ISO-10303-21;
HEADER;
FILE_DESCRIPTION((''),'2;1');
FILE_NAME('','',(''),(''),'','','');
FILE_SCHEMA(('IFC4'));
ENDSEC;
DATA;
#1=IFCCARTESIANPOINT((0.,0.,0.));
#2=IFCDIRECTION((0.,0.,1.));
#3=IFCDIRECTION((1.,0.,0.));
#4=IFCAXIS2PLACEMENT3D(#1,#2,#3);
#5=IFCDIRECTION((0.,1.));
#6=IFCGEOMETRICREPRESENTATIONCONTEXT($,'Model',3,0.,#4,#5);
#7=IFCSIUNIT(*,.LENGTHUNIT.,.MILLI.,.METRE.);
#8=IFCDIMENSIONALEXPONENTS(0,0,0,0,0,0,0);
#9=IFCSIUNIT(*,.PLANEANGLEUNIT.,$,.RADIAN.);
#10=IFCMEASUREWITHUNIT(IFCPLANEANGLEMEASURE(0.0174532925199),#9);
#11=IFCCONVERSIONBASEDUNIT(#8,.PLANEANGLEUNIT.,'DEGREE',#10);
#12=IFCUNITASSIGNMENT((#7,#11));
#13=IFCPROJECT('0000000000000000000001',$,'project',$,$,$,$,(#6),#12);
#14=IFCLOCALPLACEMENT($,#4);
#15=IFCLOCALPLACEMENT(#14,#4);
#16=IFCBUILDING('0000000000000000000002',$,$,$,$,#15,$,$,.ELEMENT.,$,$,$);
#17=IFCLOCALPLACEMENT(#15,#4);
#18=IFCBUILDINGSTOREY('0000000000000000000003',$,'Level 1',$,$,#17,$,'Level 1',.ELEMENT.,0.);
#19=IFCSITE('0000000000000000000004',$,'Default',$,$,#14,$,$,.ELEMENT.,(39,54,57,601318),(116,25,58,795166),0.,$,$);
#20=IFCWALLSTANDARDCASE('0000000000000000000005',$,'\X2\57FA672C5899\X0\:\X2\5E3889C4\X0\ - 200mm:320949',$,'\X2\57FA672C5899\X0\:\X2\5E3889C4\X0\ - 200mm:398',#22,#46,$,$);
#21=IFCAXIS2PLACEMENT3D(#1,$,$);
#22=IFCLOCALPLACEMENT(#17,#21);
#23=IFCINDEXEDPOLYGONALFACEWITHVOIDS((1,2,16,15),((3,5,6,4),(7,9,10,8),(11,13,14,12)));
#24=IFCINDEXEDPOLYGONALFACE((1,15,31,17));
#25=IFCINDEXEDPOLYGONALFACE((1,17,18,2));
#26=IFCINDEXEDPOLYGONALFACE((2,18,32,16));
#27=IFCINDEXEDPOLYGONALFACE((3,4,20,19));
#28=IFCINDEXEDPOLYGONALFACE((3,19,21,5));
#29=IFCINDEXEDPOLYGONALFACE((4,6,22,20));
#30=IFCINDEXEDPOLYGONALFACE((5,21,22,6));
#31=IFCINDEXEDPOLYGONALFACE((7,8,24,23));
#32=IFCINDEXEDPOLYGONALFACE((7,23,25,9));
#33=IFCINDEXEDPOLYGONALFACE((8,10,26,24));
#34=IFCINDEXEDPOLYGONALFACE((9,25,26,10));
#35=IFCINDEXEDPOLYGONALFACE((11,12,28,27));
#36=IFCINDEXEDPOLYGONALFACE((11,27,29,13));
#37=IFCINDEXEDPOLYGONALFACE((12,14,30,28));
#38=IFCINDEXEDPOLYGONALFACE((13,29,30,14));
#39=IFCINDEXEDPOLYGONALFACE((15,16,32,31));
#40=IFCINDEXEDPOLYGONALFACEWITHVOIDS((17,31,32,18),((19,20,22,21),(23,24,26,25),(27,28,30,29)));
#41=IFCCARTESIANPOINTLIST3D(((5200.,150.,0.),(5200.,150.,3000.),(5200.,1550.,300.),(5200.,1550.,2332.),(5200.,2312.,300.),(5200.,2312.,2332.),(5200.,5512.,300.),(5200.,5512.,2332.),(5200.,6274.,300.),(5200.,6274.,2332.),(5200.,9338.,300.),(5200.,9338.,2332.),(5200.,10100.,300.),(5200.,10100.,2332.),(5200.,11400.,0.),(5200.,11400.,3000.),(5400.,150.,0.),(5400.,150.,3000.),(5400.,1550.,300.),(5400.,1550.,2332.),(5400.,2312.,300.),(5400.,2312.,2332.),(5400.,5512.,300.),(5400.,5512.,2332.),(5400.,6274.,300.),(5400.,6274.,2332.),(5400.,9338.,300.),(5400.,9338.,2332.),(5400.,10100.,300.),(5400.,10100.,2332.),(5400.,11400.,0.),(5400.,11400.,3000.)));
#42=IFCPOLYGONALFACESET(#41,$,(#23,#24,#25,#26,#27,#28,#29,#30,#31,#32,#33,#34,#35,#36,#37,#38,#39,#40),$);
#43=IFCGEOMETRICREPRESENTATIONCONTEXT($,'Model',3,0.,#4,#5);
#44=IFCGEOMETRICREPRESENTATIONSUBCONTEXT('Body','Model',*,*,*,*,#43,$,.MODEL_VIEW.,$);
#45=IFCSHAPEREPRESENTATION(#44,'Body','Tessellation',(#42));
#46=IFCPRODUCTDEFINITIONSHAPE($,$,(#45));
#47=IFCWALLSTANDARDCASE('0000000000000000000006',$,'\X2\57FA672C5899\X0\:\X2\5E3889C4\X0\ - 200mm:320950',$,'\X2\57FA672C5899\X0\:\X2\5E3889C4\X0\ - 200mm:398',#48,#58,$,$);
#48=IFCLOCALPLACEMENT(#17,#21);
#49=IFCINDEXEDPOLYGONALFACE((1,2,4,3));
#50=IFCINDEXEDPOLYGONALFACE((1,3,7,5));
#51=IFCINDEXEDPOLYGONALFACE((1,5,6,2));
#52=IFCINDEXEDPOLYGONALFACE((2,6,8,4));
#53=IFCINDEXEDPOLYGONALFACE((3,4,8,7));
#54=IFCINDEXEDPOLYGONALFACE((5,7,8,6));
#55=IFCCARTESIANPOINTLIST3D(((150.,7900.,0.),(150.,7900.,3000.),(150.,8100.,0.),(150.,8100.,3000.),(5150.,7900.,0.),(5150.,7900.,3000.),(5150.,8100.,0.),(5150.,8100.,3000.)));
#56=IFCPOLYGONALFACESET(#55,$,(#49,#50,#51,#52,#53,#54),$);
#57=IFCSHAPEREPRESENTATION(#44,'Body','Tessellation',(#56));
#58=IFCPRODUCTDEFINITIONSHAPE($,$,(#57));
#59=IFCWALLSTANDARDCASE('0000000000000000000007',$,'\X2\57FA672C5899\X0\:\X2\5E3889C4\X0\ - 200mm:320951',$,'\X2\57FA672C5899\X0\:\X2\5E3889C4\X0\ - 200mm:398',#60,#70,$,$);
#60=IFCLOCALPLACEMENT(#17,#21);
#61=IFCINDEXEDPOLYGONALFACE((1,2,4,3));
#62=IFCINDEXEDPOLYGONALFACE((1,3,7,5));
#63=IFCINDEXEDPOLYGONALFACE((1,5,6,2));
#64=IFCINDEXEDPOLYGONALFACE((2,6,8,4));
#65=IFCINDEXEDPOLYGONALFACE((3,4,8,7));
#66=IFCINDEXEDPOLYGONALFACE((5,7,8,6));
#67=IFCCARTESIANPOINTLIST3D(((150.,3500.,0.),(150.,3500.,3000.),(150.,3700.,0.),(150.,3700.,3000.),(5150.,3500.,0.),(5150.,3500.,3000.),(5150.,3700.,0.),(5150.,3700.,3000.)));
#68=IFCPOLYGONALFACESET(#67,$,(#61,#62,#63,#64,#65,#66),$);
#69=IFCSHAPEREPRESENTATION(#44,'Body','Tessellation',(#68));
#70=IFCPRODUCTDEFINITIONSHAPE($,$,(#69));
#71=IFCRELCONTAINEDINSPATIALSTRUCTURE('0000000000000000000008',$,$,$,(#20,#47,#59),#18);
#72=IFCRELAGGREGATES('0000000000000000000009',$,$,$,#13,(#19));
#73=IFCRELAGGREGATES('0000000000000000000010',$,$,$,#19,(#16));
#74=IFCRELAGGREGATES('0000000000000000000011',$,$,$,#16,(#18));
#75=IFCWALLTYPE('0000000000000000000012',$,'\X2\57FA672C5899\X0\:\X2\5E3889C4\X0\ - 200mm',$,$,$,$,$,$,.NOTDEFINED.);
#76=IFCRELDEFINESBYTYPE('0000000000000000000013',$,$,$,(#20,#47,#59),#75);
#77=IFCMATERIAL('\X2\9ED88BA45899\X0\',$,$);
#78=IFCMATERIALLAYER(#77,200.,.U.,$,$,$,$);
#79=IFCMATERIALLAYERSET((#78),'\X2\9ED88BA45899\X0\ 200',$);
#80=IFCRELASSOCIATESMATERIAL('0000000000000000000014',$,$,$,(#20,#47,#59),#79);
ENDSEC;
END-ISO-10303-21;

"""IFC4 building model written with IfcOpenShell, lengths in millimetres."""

from ifc_helpers import new_model, entity, si_unit, converted_unit, direction, frame, origin_with_axes, place, context, subcontext, project, spatial, polyline, outline, extrude, material, layer, layer_set, layer_usage, type_object, element, save


model = new_model("IFC4")

# Units and contexts
model_context_1 = context("Model", 3, precision=0.0, world=origin_with_axes(), true_north=direction((0.0, 1.0)))
model_context_2 = context("Model", 3, precision=0.0, world=origin_with_axes(), true_north=direction((0.0, 1.0)))
body_context_1 = subcontext(model_context_2, "Body", "Model", "MODEL_VIEW")
ifc_project = project(units=[si_unit("LENGTHUNIT", "METRE", prefix="MILLI"), converted_unit("PLANEANGLEUNIT", "DEGREE", entity("IfcPlaneAngleMeasure", 0.0174532925199), si_unit("PLANEANGLEUNIT", "RADIAN"), dimensions=[0, 0, 0, 0, 0, 0, 0])], contexts=[model_context_1])

# Site, building, storey
site_placement = place(None, origin_with_axes())
site = spatial("IfcSite", under=ifc_project, at=site_placement, Name="Default", CompositionType="ELEMENT", RefLatitude=(39, 54, 57, 601318), RefLongitude=(116, 25, 58, 795166), RefElevation=0.0)
building_placement = place(site_placement, origin_with_axes())
building = spatial("IfcBuilding", under=site, at=building_placement, CompositionType="ELEMENT")
storey_placement = place(building_placement, origin_with_axes())
storey = spatial("IfcBuildingStorey", under=building, at=storey_placement, Name="Level 1", LongName="Level 1", CompositionType="ELEMENT", Elevation=0.0)

# Shared definitions
placement_1 = place(None, origin_with_axes())
placement_2 = place(placement_1, origin_with_axes())
placement_3 = place(placement_2, origin_with_axes())

# Wall, openings
ifc_material_1 = material(Name="默认墙")
ifc_layer_1 = layer(ifc_material_1, 200.0, ventilated="UNKNOWN")
ifc_layer_set_1 = layer_set([ifc_layer_1], Name="默认墙 200")
ifc_layer_usage_1 = layer_usage(ifc_layer_set_1, "AXIS2", "POSITIVE", -100.0)
wall_type_1 = type_object("IfcWallType", Name="基本墙:常规 - 200mm", PredefinedType="NOTDEFINED")
wall_1_placement = place(placement_3, frame((5300.0, 11500.0, 0.0), z_axis=(0.0, 0.0, 1.0), x_axis=(0.0, -1.0, 0.0)))
wall_1 = element("IfcWallStandardCase", 1, at=wall_1_placement, inside=storey, type_object=wall_type_1, material=ifc_layer_usage_1, Name="基本墙:常规 - 200mm:320949", ObjectType="基本墙:常规 - 200mm:398", context=body_context_1, shape_type="SweptSolid", body=[
    extrude(outline(polyline([(100.0, -100.0), (11350.0, -100.0), (11350.0, 100.0), (100.0, 100.0), (100.0, -100.0)])), origin_with_axes(), (0.0, 0.0, 1.0), 3000.0),
])
opening_1_placement = place(wall_1_placement, frame((9569.0, 0.0, 300.0), z_axis=(0.0, 0.0, 1.0), x_axis=(1.0, 0.0, 0.0)))
element("IfcOpeningElement", 2, at=opening_1_placement, cuts=wall_1, context=body_context_1, shape_type="SweptSolid", body=[
    extrude(outline(polyline([(-381.0, -2032.0), (381.0, -2032.0), (381.0, 0.0), (-381.0, 0.0), (-381.0, -2032.0)])), frame((0.0, -100.0, 0.0), z_axis=(0.0, 1.0, 0.0), x_axis=(1.0, 0.0, 0.0)), (0.0, 0.0, 1.0), 200.0),
])
opening_2_placement = place(wall_1_placement, frame((5607.0, 0.0, 300.0), z_axis=(0.0, 0.0, 1.0), x_axis=(1.0, 0.0, 0.0)))
element("IfcOpeningElement", 3, at=opening_2_placement, cuts=wall_1, context=body_context_1, shape_type="SweptSolid", body=[
    extrude(outline(polyline([(-381.0, -2032.0), (381.0, -2032.0), (381.0, 0.0), (-381.0, 0.0), (-381.0, -2032.0)])), frame((0.0, -100.0, 0.0), z_axis=(0.0, 1.0, 0.0), x_axis=(1.0, 0.0, 0.0)), (0.0, 0.0, 1.0), 200.0),
])
opening_3_placement = place(wall_1_placement, frame((1781.0, 0.0, 300.0), z_axis=(0.0, 0.0, 1.0), x_axis=(1.0, 0.0, 0.0)))
element("IfcOpeningElement", 4, at=opening_3_placement, cuts=wall_1, context=body_context_1, shape_type="SweptSolid", body=[
    extrude(outline(polyline([(-381.0, -2032.0), (381.0, -2032.0), (381.0, 0.0), (-381.0, 0.0), (-381.0, -2032.0)])), frame((0.0, -100.0, 0.0), z_axis=(0.0, 1.0, 0.0), x_axis=(1.0, 0.0, 0.0)), (0.0, 0.0, 1.0), 200.0),
])

# Walls
ifc_layer_usage_2 = layer_usage(ifc_layer_set_1, "AXIS2", "POSITIVE", -100.0)
wall_2_placement = place(placement_3, frame((150.0, 8000.0, 0.0), z_axis=(0.0, 0.0, 1.0), x_axis=(1.0, 0.0, 0.0)))
element("IfcWallStandardCase", 5, at=wall_2_placement, inside=storey, type_object=wall_type_1, material=ifc_layer_usage_2, Name="基本墙:常规 - 200mm:320950", ObjectType="基本墙:常规 - 200mm:398", context=body_context_1, shape_type="SweptSolid", body=[
    extrude(outline(polyline([(0.0, -100.0), (5000.0, -100.0), (5000.0, 100.0), (0.0, 100.0), (0.0, -100.0)])), origin_with_axes(), (0.0, 0.0, 1.0), 3000.0),
])
ifc_layer_usage_3 = layer_usage(ifc_layer_set_1, "AXIS2", "POSITIVE", -100.0)
wall_3_placement = place(placement_3, frame((150.0, 3600.0, 0.0), z_axis=(0.0, 0.0, 1.0), x_axis=(1.0, 0.0, 0.0)))
element("IfcWallStandardCase", 6, at=wall_3_placement, inside=storey, type_object=wall_type_1, material=ifc_layer_usage_3, Name="基本墙:常规 - 200mm:320951", ObjectType="基本墙:常规 - 200mm:398", context=body_context_1, shape_type="SweptSolid", body=[
    extrude(outline(polyline([(0.0, -100.0), (5000.0, -100.0), (5000.0, 100.0), (0.0, 100.0), (0.0, -100.0)])), origin_with_axes(), (0.0, 0.0, 1.0), 3000.0),
])

save(model, "model.ifc")
